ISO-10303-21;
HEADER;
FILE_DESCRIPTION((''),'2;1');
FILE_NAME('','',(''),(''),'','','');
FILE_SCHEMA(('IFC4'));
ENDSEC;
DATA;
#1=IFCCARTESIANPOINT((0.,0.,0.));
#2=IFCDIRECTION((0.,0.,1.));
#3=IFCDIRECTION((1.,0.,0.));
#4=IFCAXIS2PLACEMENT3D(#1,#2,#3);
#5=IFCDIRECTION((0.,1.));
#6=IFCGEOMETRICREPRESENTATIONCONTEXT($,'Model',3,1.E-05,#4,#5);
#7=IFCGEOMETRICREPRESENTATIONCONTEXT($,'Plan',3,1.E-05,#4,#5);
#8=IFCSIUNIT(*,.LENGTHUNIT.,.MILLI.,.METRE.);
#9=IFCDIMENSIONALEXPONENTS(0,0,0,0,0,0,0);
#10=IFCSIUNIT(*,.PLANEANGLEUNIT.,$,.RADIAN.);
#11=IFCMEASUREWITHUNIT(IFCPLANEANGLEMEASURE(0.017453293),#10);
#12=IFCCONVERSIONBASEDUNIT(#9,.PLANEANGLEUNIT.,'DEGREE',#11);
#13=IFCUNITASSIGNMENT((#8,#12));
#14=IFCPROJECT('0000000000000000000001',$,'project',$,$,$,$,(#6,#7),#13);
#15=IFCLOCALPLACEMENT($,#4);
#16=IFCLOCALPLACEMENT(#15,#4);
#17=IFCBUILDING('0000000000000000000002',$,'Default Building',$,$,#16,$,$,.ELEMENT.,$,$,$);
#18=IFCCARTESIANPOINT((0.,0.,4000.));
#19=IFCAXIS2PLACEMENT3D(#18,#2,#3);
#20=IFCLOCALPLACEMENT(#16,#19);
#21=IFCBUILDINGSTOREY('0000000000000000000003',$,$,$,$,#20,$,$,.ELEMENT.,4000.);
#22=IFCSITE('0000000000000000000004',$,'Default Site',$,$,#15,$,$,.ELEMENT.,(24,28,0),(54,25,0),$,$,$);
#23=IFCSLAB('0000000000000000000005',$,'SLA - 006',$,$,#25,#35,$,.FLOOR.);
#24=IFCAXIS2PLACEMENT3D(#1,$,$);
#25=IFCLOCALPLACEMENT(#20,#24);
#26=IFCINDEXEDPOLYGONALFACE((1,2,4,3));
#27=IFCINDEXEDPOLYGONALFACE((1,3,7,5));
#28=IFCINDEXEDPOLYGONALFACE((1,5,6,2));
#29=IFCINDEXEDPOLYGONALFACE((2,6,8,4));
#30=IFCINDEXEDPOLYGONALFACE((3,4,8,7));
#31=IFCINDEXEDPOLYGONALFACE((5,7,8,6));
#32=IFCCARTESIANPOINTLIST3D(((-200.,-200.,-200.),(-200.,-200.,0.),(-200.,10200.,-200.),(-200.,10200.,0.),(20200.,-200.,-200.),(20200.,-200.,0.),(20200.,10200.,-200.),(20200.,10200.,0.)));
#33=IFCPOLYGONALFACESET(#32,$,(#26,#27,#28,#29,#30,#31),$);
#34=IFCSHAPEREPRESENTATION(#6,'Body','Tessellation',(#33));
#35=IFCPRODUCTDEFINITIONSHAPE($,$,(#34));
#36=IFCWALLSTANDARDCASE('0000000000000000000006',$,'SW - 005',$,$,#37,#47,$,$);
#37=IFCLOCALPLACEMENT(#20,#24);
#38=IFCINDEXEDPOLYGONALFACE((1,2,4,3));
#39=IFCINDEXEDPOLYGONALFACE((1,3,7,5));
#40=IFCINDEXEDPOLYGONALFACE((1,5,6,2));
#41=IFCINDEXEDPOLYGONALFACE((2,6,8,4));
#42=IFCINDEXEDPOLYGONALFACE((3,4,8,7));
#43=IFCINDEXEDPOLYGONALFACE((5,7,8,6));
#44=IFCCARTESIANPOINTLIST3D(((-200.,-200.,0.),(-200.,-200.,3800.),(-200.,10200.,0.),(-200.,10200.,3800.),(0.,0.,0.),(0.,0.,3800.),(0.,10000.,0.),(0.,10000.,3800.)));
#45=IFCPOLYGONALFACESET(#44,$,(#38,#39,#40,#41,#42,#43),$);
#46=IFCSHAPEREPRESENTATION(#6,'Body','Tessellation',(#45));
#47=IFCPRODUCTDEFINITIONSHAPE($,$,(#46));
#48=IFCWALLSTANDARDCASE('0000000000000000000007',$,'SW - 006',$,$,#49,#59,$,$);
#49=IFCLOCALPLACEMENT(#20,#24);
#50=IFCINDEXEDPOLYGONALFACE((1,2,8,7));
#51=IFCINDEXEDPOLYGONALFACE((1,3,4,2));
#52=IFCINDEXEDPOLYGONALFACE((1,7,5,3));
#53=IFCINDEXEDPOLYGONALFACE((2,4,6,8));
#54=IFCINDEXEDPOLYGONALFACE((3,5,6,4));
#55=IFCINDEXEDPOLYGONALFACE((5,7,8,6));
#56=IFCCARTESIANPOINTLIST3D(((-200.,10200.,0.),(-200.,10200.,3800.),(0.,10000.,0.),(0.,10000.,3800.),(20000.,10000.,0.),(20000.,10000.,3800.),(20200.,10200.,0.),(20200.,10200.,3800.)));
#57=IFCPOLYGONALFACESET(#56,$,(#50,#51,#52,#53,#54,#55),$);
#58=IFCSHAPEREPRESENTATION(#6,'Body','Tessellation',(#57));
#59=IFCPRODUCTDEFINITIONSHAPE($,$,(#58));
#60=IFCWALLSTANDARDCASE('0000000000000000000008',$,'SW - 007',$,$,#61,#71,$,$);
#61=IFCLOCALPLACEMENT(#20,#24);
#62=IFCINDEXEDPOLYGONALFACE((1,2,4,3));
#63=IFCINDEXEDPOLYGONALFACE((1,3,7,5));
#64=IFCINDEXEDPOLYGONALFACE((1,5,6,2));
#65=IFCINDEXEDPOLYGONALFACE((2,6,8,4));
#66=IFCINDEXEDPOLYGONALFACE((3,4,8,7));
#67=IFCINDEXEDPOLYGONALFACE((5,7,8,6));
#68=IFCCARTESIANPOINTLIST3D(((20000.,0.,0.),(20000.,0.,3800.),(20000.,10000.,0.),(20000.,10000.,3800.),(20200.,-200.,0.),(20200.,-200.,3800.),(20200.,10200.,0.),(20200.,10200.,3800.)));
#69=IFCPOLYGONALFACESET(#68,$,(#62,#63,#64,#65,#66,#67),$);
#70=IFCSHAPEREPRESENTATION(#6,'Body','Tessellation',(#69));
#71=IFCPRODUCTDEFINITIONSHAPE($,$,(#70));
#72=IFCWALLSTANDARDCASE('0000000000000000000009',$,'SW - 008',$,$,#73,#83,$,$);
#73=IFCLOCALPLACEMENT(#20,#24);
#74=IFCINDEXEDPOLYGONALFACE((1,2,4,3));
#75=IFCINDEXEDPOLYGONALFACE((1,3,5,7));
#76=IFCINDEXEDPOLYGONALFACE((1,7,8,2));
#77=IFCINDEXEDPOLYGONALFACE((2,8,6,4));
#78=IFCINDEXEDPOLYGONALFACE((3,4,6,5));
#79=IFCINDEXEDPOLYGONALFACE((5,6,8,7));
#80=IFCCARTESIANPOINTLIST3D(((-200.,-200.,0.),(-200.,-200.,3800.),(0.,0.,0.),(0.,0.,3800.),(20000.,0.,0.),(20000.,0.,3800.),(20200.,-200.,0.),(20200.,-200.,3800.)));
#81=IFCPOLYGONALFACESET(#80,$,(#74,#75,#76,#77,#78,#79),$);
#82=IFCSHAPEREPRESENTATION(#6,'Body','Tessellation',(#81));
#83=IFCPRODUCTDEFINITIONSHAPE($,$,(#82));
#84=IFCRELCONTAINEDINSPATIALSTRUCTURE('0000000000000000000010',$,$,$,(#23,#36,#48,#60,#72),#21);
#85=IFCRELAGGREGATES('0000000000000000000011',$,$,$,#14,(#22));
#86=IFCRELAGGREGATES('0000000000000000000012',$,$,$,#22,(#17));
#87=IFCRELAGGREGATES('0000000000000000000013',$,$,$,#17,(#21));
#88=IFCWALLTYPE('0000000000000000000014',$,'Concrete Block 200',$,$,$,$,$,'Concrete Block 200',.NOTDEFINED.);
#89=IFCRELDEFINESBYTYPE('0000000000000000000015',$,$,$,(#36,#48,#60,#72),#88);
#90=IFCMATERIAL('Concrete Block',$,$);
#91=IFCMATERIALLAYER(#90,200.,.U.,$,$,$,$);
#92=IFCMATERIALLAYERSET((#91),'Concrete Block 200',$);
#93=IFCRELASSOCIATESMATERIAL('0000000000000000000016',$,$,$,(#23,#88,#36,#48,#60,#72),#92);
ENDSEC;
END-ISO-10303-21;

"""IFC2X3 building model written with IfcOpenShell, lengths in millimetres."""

from ifc_helpers import new_model, entity, si_unit, converted_unit, direction, frame, origin_with_axes, place, context, project, spatial, polyline, outline, extrude, material, layer, layer_set, layer_usage, type_object, element, save


model = new_model("IFC2X3")

# Units and contexts
model_context = context("Model", 3, precision=1e-05, world=origin_with_axes(), true_north=direction((0.0, 1.0)))
plan_context = context("Plan", 3, precision=1e-05, world=origin_with_axes(), true_north=direction((0.0, 1.0)))
ifc_project = project(units=[si_unit("LENGTHUNIT", "METRE", prefix="MILLI"), converted_unit("PLANEANGLEUNIT", "DEGREE", entity("IfcPlaneAngleMeasure", 0.017453293), si_unit("PLANEANGLEUNIT", "RADIAN"), dimensions=[0, 0, 0, 0, 0, 0, 0])], contexts=[model_context, plan_context])

# Site, building, storey
site_placement = place(None, origin_with_axes())
site = spatial("IfcSite", under=ifc_project, at=site_placement, Name="Default Site", CompositionType="ELEMENT", RefLatitude=(24, 28, 0), RefLongitude=(54, 25, 0))
building_placement = place(site_placement, origin_with_axes())
building = spatial("IfcBuilding", under=site, at=building_placement, Name="Default Building", CompositionType="ELEMENT")
storey_placement = place(building_placement, frame((0.0, 0.0, 4000.0), z_axis=(0.0, 0.0, 1.0), x_axis=(1.0, 0.0, 0.0)))
storey = spatial("IfcBuildingStorey", under=building, at=storey_placement, CompositionType="ELEMENT", Elevation=4000.0)

# Slab
ifc_material = material(Name="Concrete Block")
ifc_layer = layer(ifc_material, 200.0, ventilated="UNKNOWN")
ifc_layer_set = layer_set([ifc_layer], Name="Concrete Block 200")
ifc_layer_usage_1 = layer_usage(ifc_layer_set, "AXIS3", "NEGATIVE", 200.0)
slab_placement = place(storey_placement, frame((-200.0, 10200.0, -200.0), z_axis=(0.0, 0.0, 1.0), x_axis=(1.0, 0.0, 0.0)))
element("IfcSlab", 1, at=slab_placement, inside=storey, material=ifc_layer_usage_1, Name="SLA - 006", PredefinedType="FLOOR", context=model_context, shape_type="SweptSolid", body=[
    extrude(outline(polyline([(0.0, 0.0), (20400.0, 0.0), (20400.0, -10400.0), (0.0, -10400.0), (0.0, 0.0)])), origin_with_axes(), (0.0, 0.0, 1.0), 200.0),
])

# Walls
ifc_layer_usage_2 = layer_usage(ifc_layer_set, "AXIS2", "POSITIVE", 0.0)
wall_type = type_object("IfcWallType", Name="Concrete Block 200", ElementType="Concrete Block 200", PredefinedType="NOTDEFINED", material=ifc_layer_set)
wall_1_placement = place(storey_placement, frame((0.0, 0.0, 0.0), z_axis=(0.0, 0.0, 1.0), x_axis=(0.0, 1.0, 0.0)))
element("IfcWallStandardCase", 2, at=wall_1_placement, inside=storey, type_object=wall_type, material=ifc_layer_usage_2, Name="SW - 005", context=model_context, shape_type="SweptSolid", body=[
    extrude(outline(polyline([(0.0, 0.0), (10000.0, 0.0), (10200.0, 200.0), (-200.0, 200.0), (0.0, 0.0)])), origin_with_axes(), (0.0, 0.0, 1.0), 3800.0),
])
ifc_layer_usage_3 = layer_usage(ifc_layer_set, "AXIS2", "POSITIVE", 0.0)
wall_2_placement = place(storey_placement, frame((0.0, 10000.0, 0.0), z_axis=(0.0, 0.0, 1.0), x_axis=(1.0, 0.0, 0.0)))
element("IfcWallStandardCase", 3, at=wall_2_placement, inside=storey, type_object=wall_type, material=ifc_layer_usage_3, Name="SW - 006", context=model_context, shape_type="SweptSolid", body=[
    extrude(outline(polyline([(0.0, 0.0), (20000.0, 0.0), (20200.0, 200.0), (-200.0, 200.0), (0.0, 0.0)])), origin_with_axes(), (0.0, 0.0, 1.0), 3800.0),
])
ifc_layer_usage_4 = layer_usage(ifc_layer_set, "AXIS2", "POSITIVE", 0.0)
wall_3_placement = place(storey_placement, frame((20000.0, 10000.0, 0.0), z_axis=(0.0, 0.0, 1.0), x_axis=(0.0, -1.0, 0.0)))
element("IfcWallStandardCase", 4, at=wall_3_placement, inside=storey, type_object=wall_type, material=ifc_layer_usage_4, Name="SW - 007", context=model_context, shape_type="SweptSolid", body=[
    extrude(outline(polyline([(0.0, 0.0), (10000.0, 0.0), (10200.0, 200.0), (-200.0, 200.0), (0.0, 0.0)])), origin_with_axes(), (0.0, 0.0, 1.0), 3800.0),
])
ifc_layer_usage_5 = layer_usage(ifc_layer_set, "AXIS2", "POSITIVE", 0.0)
wall_4_placement = place(storey_placement, frame((20000.0, 0.0, 0.0), z_axis=(0.0, 0.0, 1.0), x_axis=(-1.0, 0.0, 0.0)))
element("IfcWallStandardCase", 5, at=wall_4_placement, inside=storey, type_object=wall_type, material=ifc_layer_usage_5, Name="SW - 008", context=model_context, shape_type="SweptSolid", body=[
    extrude(outline(polyline([(0.0, 0.0), (20000.0, 0.0), (20200.0, 200.0), (-200.0, 200.0), (0.0, 0.0)])), origin_with_axes(), (0.0, 0.0, 1.0), 3800.0),
])

save(model, "model.ifc")
